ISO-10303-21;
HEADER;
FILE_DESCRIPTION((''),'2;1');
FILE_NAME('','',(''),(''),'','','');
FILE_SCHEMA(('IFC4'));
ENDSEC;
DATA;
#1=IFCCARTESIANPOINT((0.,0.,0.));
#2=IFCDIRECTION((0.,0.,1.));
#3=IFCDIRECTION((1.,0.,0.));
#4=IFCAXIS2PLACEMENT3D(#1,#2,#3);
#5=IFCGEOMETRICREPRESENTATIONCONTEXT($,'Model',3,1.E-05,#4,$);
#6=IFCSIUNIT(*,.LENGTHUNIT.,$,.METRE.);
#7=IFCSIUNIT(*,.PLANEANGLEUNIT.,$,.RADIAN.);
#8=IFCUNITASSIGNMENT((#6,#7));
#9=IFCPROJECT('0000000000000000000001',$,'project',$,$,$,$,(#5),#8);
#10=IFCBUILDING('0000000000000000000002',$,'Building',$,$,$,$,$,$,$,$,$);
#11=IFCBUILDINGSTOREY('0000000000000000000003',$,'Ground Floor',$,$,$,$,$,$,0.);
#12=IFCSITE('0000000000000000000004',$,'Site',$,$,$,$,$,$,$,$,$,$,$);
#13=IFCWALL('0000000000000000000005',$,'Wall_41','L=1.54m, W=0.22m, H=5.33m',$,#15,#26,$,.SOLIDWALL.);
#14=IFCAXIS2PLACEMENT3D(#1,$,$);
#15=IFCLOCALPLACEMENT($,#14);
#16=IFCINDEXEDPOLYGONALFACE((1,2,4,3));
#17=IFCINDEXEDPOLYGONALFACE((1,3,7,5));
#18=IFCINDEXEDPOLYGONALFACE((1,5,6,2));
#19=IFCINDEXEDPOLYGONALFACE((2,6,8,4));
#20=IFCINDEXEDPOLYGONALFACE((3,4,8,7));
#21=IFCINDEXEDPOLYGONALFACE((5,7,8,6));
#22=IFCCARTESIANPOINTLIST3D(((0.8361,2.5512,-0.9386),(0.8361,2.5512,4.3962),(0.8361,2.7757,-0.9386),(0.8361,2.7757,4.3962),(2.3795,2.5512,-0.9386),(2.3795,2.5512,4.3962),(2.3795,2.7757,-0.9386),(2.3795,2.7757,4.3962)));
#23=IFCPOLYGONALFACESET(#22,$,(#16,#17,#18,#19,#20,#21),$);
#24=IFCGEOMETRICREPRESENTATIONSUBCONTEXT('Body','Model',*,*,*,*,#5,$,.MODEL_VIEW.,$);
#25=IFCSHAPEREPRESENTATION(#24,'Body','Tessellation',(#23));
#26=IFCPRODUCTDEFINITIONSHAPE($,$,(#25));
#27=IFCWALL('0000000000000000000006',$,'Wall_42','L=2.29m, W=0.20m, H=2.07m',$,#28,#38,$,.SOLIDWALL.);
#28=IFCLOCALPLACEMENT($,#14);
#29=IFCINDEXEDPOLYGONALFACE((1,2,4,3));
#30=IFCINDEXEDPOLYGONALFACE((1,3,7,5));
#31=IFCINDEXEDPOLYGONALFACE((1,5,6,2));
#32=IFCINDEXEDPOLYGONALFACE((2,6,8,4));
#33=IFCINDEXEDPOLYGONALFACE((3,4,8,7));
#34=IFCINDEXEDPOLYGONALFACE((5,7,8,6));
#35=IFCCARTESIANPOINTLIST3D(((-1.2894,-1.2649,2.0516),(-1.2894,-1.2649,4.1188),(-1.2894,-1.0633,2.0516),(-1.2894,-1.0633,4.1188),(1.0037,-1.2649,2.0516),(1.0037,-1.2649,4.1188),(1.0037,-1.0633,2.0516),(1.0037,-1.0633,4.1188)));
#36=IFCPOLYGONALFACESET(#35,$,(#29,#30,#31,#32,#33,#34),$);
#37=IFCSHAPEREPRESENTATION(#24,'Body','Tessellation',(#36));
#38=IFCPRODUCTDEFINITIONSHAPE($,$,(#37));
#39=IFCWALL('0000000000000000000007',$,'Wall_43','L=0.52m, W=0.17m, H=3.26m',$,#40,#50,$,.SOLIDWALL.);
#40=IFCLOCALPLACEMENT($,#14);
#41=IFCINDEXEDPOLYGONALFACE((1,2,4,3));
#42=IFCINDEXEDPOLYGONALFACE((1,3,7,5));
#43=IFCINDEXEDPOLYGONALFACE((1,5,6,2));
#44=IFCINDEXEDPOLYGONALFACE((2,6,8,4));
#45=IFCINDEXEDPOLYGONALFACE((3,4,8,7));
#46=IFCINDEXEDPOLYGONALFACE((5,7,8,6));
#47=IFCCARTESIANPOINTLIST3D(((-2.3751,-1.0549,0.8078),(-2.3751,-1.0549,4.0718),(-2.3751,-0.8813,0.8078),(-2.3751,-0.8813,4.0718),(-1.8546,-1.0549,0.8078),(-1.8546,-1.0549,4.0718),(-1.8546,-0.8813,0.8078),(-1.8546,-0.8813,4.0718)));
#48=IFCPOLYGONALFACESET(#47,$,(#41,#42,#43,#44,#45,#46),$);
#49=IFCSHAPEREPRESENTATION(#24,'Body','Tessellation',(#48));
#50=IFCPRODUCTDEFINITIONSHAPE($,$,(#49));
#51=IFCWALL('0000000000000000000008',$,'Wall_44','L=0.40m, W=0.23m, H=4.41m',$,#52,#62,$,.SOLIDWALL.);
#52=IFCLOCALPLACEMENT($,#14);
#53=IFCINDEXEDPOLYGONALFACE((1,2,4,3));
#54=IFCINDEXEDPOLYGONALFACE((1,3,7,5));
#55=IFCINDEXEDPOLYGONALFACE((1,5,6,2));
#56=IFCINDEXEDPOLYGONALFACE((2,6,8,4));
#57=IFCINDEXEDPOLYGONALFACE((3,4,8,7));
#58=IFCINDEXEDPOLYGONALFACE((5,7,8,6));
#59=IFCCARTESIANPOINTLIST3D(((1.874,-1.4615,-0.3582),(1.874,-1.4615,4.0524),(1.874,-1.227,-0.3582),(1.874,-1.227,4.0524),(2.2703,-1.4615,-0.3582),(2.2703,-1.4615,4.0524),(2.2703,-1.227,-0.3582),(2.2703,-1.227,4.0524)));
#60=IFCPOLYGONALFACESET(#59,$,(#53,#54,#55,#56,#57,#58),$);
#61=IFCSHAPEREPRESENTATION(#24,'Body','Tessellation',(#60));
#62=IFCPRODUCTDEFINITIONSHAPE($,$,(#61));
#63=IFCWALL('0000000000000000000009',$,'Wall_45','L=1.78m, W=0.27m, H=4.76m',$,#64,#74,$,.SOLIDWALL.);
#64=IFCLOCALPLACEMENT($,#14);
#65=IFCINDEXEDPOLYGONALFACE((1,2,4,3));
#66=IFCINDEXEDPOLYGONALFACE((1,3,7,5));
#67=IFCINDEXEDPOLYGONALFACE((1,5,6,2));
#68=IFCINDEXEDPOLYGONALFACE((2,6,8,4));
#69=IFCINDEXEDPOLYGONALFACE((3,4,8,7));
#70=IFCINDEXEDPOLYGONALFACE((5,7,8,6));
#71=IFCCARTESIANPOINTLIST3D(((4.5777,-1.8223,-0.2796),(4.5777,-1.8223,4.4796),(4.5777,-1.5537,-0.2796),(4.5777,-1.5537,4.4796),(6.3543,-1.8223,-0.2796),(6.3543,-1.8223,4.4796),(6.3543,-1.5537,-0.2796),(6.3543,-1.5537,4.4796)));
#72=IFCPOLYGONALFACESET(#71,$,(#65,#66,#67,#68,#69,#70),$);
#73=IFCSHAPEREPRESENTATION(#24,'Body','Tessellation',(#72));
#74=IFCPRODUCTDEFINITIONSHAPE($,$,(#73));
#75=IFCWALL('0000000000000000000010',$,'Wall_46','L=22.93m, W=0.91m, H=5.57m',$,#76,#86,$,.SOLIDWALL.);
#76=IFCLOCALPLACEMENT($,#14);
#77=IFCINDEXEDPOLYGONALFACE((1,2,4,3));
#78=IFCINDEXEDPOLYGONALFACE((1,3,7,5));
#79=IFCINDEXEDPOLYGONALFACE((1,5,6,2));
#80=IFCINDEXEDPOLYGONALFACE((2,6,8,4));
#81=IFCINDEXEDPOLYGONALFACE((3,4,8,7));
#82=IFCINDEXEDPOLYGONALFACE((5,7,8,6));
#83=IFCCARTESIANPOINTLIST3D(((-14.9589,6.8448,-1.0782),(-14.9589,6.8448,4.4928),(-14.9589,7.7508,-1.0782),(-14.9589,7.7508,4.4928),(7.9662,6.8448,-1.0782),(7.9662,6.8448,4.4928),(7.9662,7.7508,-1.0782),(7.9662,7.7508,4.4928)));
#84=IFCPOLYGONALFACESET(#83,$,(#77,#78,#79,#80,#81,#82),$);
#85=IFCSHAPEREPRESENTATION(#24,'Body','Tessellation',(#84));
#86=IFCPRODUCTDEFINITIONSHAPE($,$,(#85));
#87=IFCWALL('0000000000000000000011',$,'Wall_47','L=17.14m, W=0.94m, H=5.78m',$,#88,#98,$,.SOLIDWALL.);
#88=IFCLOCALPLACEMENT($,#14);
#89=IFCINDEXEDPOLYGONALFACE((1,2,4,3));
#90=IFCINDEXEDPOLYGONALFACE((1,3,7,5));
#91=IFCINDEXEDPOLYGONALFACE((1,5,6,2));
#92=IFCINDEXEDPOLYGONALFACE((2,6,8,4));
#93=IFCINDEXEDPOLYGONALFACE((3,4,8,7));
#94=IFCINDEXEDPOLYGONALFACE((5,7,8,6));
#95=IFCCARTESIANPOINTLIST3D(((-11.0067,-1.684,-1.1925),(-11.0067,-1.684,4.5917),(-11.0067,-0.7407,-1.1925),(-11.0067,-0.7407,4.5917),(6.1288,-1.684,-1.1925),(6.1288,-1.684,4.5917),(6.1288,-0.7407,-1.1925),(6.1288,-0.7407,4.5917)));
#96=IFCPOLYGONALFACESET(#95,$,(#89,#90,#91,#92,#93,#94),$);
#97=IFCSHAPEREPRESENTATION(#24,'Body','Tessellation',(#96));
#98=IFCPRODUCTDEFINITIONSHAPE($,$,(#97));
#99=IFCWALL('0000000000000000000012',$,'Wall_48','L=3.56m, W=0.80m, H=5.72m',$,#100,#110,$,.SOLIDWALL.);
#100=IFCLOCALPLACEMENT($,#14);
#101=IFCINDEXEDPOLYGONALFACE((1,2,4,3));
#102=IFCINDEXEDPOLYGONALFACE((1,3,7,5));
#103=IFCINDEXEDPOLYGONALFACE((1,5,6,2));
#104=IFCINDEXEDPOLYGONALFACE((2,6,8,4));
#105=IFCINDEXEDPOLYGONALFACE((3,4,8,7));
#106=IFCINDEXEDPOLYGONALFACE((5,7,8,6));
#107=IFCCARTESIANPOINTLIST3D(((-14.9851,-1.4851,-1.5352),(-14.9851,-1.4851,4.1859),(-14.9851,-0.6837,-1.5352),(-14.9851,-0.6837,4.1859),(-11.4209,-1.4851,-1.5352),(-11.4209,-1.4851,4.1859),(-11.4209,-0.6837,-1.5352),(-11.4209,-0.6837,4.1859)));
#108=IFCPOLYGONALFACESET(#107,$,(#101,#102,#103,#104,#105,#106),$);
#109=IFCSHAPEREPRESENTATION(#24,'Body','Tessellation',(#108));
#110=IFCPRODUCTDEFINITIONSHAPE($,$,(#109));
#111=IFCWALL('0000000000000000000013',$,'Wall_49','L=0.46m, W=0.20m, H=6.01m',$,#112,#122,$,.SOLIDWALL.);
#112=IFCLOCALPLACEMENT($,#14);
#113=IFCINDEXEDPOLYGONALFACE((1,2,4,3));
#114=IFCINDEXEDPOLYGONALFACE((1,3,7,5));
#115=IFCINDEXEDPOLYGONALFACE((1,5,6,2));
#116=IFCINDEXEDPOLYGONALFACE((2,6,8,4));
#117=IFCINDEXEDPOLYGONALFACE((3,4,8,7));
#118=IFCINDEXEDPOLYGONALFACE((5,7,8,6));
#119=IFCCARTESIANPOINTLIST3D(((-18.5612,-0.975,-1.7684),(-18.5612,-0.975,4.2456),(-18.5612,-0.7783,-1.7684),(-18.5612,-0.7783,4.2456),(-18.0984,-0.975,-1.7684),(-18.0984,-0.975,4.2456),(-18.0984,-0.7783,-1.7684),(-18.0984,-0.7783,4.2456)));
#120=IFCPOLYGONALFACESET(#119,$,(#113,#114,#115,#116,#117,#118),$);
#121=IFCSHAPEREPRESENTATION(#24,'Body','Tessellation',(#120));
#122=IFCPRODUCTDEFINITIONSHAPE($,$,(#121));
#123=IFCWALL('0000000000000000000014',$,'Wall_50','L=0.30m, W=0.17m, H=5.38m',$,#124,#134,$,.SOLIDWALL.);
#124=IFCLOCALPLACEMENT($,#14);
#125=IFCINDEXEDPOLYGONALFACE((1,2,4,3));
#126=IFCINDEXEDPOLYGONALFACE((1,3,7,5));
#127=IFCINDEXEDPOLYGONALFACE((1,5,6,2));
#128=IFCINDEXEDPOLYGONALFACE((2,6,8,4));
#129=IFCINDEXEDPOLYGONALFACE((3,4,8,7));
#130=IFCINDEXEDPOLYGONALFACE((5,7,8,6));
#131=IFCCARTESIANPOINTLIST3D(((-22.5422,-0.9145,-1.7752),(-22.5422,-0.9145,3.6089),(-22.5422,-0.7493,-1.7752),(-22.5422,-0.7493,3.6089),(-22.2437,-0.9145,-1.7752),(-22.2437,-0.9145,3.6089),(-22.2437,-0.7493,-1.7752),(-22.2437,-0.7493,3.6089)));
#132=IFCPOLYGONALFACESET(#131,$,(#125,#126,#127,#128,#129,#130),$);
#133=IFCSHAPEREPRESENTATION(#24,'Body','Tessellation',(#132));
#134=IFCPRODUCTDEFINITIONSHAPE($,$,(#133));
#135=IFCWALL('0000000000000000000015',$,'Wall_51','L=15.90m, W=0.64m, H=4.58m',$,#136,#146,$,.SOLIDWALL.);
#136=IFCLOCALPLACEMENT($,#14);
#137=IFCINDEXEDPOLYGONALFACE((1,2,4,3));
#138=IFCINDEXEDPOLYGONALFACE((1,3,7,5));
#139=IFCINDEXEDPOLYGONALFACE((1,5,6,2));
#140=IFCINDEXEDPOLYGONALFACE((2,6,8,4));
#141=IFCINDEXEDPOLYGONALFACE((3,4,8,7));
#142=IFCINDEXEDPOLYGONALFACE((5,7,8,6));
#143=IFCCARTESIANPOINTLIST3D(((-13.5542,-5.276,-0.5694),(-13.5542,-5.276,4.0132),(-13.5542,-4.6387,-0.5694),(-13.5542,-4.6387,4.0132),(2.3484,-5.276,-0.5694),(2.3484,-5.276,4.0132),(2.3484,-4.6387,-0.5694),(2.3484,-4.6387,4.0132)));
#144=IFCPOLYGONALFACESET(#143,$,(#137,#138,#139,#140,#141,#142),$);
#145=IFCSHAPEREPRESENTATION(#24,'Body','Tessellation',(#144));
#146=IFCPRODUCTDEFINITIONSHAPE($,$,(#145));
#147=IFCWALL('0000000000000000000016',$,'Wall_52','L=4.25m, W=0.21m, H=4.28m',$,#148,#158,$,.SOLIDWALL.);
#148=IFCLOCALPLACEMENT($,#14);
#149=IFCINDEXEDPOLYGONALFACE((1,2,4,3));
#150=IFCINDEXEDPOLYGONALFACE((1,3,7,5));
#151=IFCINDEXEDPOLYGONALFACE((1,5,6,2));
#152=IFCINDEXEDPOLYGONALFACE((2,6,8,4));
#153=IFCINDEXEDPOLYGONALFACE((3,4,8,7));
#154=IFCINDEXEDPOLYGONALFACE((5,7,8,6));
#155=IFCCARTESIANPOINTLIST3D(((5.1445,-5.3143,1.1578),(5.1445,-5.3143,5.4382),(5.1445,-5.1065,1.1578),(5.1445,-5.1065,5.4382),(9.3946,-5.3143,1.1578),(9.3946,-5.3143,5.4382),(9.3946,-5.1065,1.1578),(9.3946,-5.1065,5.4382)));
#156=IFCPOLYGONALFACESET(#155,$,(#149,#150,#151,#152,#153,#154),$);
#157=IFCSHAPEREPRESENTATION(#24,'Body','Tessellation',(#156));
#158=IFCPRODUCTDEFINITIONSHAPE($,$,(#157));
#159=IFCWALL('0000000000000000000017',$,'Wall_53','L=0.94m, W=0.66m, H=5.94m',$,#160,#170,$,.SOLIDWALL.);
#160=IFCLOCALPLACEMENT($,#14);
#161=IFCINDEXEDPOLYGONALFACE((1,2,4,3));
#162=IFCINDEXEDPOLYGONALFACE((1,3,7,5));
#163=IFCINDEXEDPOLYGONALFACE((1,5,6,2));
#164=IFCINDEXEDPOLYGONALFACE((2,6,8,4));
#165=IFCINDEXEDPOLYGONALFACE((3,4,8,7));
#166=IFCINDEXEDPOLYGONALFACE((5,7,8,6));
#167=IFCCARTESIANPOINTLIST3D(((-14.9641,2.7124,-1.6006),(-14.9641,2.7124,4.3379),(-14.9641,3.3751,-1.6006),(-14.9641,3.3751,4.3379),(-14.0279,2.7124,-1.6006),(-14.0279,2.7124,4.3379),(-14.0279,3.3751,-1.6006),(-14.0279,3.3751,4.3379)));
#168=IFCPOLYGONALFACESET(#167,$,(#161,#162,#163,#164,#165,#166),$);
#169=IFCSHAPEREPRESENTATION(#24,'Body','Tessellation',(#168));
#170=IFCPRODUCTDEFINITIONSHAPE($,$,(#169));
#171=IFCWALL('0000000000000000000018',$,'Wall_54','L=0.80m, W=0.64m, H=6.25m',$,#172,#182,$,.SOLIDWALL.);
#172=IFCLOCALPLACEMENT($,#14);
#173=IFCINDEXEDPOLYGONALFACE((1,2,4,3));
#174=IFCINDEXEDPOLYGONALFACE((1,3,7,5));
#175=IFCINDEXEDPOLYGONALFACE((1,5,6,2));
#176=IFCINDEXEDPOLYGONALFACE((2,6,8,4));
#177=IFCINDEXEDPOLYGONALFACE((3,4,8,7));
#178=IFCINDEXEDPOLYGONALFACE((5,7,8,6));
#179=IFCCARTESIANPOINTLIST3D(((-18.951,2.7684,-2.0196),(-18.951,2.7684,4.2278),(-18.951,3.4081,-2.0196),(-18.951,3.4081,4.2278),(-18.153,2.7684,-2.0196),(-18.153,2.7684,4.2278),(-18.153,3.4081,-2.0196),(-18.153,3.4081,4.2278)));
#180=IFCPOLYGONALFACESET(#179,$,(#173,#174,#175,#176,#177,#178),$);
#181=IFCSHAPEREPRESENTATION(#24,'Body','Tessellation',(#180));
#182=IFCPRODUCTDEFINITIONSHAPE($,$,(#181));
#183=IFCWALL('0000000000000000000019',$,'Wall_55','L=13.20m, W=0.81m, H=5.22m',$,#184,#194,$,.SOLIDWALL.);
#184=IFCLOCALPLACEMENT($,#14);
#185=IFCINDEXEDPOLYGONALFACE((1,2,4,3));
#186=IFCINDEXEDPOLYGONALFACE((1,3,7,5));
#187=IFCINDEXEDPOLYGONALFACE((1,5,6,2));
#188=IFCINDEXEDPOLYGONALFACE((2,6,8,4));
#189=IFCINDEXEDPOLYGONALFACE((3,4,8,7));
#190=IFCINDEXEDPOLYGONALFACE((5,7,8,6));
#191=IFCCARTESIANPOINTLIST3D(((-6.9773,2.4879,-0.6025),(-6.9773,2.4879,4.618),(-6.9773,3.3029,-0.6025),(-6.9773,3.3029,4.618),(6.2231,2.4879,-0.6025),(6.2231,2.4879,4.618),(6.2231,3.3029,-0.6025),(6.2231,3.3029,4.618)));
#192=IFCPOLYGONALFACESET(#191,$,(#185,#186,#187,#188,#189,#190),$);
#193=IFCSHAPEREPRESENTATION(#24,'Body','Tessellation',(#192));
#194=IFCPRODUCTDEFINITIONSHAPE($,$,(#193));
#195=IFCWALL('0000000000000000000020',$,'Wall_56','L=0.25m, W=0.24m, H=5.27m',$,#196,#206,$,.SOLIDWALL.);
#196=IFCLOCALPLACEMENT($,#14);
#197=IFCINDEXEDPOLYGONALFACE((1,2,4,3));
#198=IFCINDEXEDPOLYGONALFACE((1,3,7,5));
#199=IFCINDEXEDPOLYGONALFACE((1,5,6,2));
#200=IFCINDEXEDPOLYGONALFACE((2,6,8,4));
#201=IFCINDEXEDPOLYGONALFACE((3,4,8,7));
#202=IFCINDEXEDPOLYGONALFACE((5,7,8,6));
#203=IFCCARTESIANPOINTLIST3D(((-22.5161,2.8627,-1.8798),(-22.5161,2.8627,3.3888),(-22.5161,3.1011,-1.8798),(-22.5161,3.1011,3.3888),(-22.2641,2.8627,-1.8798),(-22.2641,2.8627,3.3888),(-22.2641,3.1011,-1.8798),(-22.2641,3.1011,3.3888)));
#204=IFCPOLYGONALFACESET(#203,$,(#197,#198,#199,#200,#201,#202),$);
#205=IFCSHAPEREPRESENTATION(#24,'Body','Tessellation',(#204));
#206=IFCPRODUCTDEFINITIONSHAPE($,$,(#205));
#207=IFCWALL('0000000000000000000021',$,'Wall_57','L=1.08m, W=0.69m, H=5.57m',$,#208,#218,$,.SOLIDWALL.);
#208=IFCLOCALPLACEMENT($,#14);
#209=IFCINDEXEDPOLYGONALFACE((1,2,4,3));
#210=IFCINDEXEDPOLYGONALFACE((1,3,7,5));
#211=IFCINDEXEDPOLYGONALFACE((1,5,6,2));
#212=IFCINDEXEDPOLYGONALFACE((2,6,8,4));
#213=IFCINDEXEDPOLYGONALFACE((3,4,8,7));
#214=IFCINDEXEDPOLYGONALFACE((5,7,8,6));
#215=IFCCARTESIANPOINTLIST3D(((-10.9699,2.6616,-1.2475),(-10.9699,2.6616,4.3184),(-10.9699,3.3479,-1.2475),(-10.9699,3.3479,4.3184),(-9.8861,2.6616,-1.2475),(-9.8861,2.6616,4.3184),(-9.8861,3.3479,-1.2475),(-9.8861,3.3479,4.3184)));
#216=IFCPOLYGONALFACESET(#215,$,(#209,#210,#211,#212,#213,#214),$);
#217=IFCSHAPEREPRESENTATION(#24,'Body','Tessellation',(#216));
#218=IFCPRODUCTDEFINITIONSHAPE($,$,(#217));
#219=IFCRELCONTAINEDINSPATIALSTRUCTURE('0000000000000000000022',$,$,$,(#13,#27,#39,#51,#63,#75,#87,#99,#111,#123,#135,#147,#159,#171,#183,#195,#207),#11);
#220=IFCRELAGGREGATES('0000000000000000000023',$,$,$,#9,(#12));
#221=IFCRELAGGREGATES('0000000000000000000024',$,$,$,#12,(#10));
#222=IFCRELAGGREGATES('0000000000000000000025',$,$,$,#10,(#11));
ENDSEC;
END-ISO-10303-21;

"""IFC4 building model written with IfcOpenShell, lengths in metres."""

from ifc_helpers import new_model, si_unit, frame, origin_with_axes, origin_2d, context, subcontext, project, spatial, rectangle, extrude, element, save


model = new_model("IFC4")

# Units and contexts
model_context = context("Model", 3, precision=1e-05, world=origin_with_axes())
body_context = subcontext(model_context, "Body", "Model", "MODEL_VIEW")
ifc_project = project(units=[si_unit("LENGTHUNIT", "METRE"), si_unit("PLANEANGLEUNIT", "RADIAN")], contexts=[model_context])

# Site, building, storey
site = spatial("IfcSite", under=ifc_project, Name="Site")
building = spatial("IfcBuilding", under=site, Name="Building")
storey = spatial("IfcBuildingStorey", under=building, Name="Ground Floor", Elevation=0.0)

# Walls
element("IfcWall", 1, inside=storey, Name="Wall_41", Description="L=1.54m, W=0.22m, H=5.33m", PredefinedType="SOLIDWALL", context=body_context, shape_type="SweptSolid", body=[
    extrude(rectangle(XDim=1.5434, YDim=0.2246, at=origin_2d()), frame((1.6078, 2.6634, -0.9386), z_axis=(0.0, 0.0, 1.0), x_axis=(1.0, 0.0, 0.0)), (0.0, 0.0, 1.0), 5.3348),
])
element("IfcWall", 2, inside=storey, Name="Wall_42", Description="L=2.29m, W=0.20m, H=2.07m", PredefinedType="SOLIDWALL", context=body_context, shape_type="SweptSolid", body=[
    extrude(rectangle(XDim=2.293, YDim=0.2016, at=origin_2d()), frame((-0.1429, -1.1641, 2.0516), z_axis=(0.0, 0.0, 1.0), x_axis=(1.0, 0.0, 0.0)), (0.0, 0.0, 1.0), 2.0672),
])
element("IfcWall", 3, inside=storey, Name="Wall_43", Description="L=0.52m, W=0.17m, H=3.26m", PredefinedType="SOLIDWALL", context=body_context, shape_type="SweptSolid", body=[
    extrude(rectangle(XDim=0.5205, YDim=0.1736, at=origin_2d()), frame((-2.1148, -0.9681, 0.8078), z_axis=(0.0, 0.0, 1.0), x_axis=(1.0, 0.0, 0.0)), (0.0, 0.0, 1.0), 3.264),
])
element("IfcWall", 4, inside=storey, Name="Wall_44", Description="L=0.40m, W=0.23m, H=4.41m", PredefinedType="SOLIDWALL", context=body_context, shape_type="SweptSolid", body=[
    extrude(rectangle(XDim=0.3962, YDim=0.2344, at=origin_2d()), frame((2.0721, -1.3442, -0.3582), z_axis=(0.0, 0.0, 1.0), x_axis=(1.0, 0.0, 0.0)), (0.0, 0.0, 1.0), 4.4106),
])
element("IfcWall", 5, inside=storey, Name="Wall_45", Description="L=1.78m, W=0.27m, H=4.76m", PredefinedType="SOLIDWALL", context=body_context, shape_type="SweptSolid", body=[
    extrude(rectangle(XDim=1.7765, YDim=0.2686, at=origin_2d()), frame((5.466, -1.688, -0.2796), z_axis=(0.0, 0.0, 1.0), x_axis=(1.0, 0.0, 0.0)), (0.0, 0.0, 1.0), 4.7592),
])
element("IfcWall", 6, inside=storey, Name="Wall_46", Description="L=22.93m, W=0.91m, H=5.57m", PredefinedType="SOLIDWALL", context=body_context, shape_type="SweptSolid", body=[
    extrude(rectangle(XDim=22.9251, YDim=0.906, at=origin_2d()), frame((-3.4964, 7.2978, -1.0782), z_axis=(0.0, 0.0, 1.0), x_axis=(1.0, 0.0, 0.0)), (0.0, 0.0, 1.0), 5.571),
])
element("IfcWall", 7, inside=storey, Name="Wall_47", Description="L=17.14m, W=0.94m, H=5.78m", PredefinedType="SOLIDWALL", context=body_context, shape_type="SweptSolid", body=[
    extrude(rectangle(XDim=17.1355, YDim=0.9433, at=origin_2d()), frame((-2.4389, -1.2124, -1.1925), z_axis=(0.0, 0.0, 1.0), x_axis=(1.0, 0.0, 0.0)), (0.0, 0.0, 1.0), 5.7842),
])
element("IfcWall", 8, inside=storey, Name="Wall_48", Description="L=3.56m, W=0.80m, H=5.72m", PredefinedType="SOLIDWALL", context=body_context, shape_type="SweptSolid", body=[
    extrude(rectangle(XDim=3.5642, YDim=0.8014, at=origin_2d()), frame((-13.203, -1.0844, -1.5352), z_axis=(0.0, 0.0, 1.0), x_axis=(1.0, 0.0, 0.0)), (0.0, 0.0, 1.0), 5.7211),
])
element("IfcWall", 9, inside=storey, Name="Wall_49", Description="L=0.46m, W=0.20m, H=6.01m", PredefinedType="SOLIDWALL", context=body_context, shape_type="SweptSolid", body=[
    extrude(rectangle(XDim=0.4628, YDim=0.1967, at=origin_2d()), frame((-18.3298, -0.8766, -1.7684), z_axis=(0.0, 0.0, 1.0), x_axis=(1.0, 0.0, 0.0)), (0.0, 0.0, 1.0), 6.014),
])
element("IfcWall", 10, inside=storey, Name="Wall_50", Description="L=0.30m, W=0.17m, H=5.38m", PredefinedType="SOLIDWALL", context=body_context, shape_type="SweptSolid", body=[
    extrude(rectangle(XDim=0.2985, YDim=0.1652, at=origin_2d()), frame((-22.3929, -0.8319, -1.7752), z_axis=(0.0, 0.0, 1.0), x_axis=(1.0, 0.0, 0.0)), (0.0, 0.0, 1.0), 5.3841),
])
element("IfcWall", 11, inside=storey, Name="Wall_51", Description="L=15.90m, W=0.64m, H=4.58m", PredefinedType="SOLIDWALL", context=body_context, shape_type="SweptSolid", body=[
    extrude(rectangle(XDim=15.9026, YDim=0.6373, at=origin_2d()), frame((-5.6029, -4.9573, -0.5694), z_axis=(0.0, 0.0, 1.0), x_axis=(1.0, 0.0, 0.0)), (0.0, 0.0, 1.0), 4.5827),
])
element("IfcWall", 12, inside=storey, Name="Wall_52", Description="L=4.25m, W=0.21m, H=4.28m", PredefinedType="SOLIDWALL", context=body_context, shape_type="SweptSolid", body=[
    extrude(rectangle(XDim=4.2501, YDim=0.2079, at=origin_2d()), frame((7.2695, -5.2104, 1.1578), z_axis=(0.0, 0.0, 1.0), x_axis=(1.0, 0.0, 0.0)), (0.0, 0.0, 1.0), 4.2804),
])
element("IfcWall", 13, inside=storey, Name="Wall_53", Description="L=0.94m, W=0.66m, H=5.94m", PredefinedType="SOLIDWALL", context=body_context, shape_type="SweptSolid", body=[
    extrude(rectangle(XDim=0.9362, YDim=0.6626, at=origin_2d()), frame((-14.496, 3.0438, -1.6006), z_axis=(0.0, 0.0, 1.0), x_axis=(1.0, 0.0, 0.0)), (0.0, 0.0, 1.0), 5.9385),
])
element("IfcWall", 14, inside=storey, Name="Wall_54", Description="L=0.80m, W=0.64m, H=6.25m", PredefinedType="SOLIDWALL", context=body_context, shape_type="SweptSolid", body=[
    extrude(rectangle(XDim=0.7979, YDim=0.6396, at=origin_2d()), frame((-18.552, 3.0883, -2.0196), z_axis=(0.0, 0.0, 1.0), x_axis=(1.0, 0.0, 0.0)), (0.0, 0.0, 1.0), 6.2474),
])
element("IfcWall", 15, inside=storey, Name="Wall_55", Description="L=13.20m, W=0.81m, H=5.22m", PredefinedType="SOLIDWALL", context=body_context, shape_type="SweptSolid", body=[
    extrude(rectangle(XDim=13.2003, YDim=0.815, at=origin_2d()), frame((-0.3771, 2.8954, -0.6025), z_axis=(0.0, 0.0, 1.0), x_axis=(1.0, 0.0, 0.0)), (0.0, 0.0, 1.0), 5.2206),
])
element("IfcWall", 16, inside=storey, Name="Wall_56", Description="L=0.25m, W=0.24m, H=5.27m", PredefinedType="SOLIDWALL", context=body_context, shape_type="SweptSolid", body=[
    extrude(rectangle(XDim=0.252, YDim=0.2384, at=origin_2d()), frame((-22.3901, 2.9819, -1.8798), z_axis=(0.0, 0.0, 1.0), x_axis=(1.0, 0.0, 0.0)), (0.0, 0.0, 1.0), 5.2687),
])
element("IfcWall", 17, inside=storey, Name="Wall_57", Description="L=1.08m, W=0.69m, H=5.57m", PredefinedType="SOLIDWALL", context=body_context, shape_type="SweptSolid", body=[
    extrude(rectangle(XDim=1.0838, YDim=0.6863, at=origin_2d()), frame((-10.428, 3.0048, -1.2475), z_axis=(0.0, 0.0, 1.0), x_axis=(1.0, 0.0, 0.0)), (0.0, 0.0, 1.0), 5.5659),
])

save(model, "model.ifc")
